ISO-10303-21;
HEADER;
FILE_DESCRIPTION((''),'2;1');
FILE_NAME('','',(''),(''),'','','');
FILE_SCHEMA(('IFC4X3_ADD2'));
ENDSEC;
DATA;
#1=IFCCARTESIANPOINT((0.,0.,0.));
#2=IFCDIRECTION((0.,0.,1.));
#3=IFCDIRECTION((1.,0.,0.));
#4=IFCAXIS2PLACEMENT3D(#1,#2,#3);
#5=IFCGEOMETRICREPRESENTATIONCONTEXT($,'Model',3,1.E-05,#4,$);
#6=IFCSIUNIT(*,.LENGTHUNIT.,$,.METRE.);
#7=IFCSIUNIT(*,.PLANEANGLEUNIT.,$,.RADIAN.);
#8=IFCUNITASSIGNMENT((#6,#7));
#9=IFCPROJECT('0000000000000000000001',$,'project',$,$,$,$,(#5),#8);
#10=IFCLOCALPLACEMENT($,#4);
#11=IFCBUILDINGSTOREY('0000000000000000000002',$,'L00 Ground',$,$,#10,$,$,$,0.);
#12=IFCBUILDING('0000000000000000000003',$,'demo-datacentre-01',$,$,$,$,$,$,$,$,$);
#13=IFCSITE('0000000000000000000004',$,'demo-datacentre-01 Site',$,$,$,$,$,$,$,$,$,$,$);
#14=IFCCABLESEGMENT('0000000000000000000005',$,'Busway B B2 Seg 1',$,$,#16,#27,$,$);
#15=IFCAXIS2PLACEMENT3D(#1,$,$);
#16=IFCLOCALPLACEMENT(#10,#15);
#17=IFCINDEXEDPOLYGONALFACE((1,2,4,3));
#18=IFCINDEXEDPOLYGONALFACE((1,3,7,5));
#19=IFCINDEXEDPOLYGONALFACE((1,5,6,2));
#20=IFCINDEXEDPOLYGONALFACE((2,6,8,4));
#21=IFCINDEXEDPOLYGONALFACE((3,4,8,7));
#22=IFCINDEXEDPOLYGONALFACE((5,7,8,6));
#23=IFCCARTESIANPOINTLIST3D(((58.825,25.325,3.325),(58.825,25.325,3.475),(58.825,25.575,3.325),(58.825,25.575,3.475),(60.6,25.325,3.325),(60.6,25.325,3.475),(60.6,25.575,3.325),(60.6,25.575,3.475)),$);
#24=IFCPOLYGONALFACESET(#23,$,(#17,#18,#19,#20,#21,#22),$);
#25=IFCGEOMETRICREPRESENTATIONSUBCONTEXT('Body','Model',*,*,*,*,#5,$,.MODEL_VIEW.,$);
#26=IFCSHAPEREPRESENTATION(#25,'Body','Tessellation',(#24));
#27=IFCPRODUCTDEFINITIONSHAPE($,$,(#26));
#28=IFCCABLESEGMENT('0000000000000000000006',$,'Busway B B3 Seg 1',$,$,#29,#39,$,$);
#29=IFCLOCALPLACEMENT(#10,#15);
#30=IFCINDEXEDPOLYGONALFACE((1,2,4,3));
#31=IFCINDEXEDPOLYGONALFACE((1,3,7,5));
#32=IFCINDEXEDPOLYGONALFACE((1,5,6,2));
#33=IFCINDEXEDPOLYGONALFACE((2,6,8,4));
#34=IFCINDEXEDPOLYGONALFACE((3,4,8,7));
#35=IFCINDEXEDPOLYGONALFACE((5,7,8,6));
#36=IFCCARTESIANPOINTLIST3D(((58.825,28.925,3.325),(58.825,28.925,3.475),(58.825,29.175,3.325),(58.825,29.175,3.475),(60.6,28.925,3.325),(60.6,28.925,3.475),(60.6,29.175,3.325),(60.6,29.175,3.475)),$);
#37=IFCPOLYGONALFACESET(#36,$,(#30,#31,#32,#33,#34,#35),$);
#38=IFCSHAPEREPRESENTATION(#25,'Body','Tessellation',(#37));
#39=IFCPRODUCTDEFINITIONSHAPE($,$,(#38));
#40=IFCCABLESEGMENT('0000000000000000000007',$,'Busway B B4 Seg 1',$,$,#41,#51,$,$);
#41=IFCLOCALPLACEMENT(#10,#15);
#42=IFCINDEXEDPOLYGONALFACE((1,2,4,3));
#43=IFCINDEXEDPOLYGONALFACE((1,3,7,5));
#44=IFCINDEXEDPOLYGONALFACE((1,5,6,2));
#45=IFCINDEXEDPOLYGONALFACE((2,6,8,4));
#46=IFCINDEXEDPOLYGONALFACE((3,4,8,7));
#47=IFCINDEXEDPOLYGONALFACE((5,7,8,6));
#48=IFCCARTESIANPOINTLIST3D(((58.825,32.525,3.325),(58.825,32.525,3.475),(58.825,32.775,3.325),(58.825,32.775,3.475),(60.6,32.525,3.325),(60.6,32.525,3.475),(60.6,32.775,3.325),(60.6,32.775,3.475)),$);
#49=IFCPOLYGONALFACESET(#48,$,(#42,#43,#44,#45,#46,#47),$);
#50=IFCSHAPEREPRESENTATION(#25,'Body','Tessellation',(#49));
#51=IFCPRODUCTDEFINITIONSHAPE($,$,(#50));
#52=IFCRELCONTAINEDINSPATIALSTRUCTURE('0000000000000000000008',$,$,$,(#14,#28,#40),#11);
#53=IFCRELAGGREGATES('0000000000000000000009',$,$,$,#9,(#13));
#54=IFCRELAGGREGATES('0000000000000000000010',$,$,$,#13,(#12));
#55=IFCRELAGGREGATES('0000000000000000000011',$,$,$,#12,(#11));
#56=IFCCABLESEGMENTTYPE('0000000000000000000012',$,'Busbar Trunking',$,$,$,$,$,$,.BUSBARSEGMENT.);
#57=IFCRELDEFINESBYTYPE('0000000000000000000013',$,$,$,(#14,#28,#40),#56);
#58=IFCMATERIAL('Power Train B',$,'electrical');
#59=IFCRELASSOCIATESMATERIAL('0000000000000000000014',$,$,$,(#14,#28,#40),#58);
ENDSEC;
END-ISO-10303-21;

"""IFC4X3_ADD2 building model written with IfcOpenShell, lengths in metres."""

from ifc_helpers import new_model, si_unit, frame, origin_with_axes, place, context, subcontext, project, spatial, rectangle, extrude, material, type_object, element, save


model = new_model("IFC4X3_ADD2")

# Units and contexts
model_context = context("Model", 3, precision=1e-05, world=origin_with_axes())
body_context = subcontext(model_context, "Body", "Model", "MODEL_VIEW")
ifc_project = project(units=[si_unit("LENGTHUNIT", "METRE"), si_unit("PLANEANGLEUNIT", "RADIAN")], contexts=[model_context])

# Site, building, storey
site = spatial("IfcSite", under=ifc_project, Name="demo-datacentre-01 Site")
building = spatial("IfcBuilding", under=site, Name="demo-datacentre-01")
storey_placement = place(None, origin_with_axes())
storey = spatial("IfcBuildingStorey", under=building, at=storey_placement, Name="L00 Ground", Elevation=0.0)

# Shared definitions
ifc_material = material(Name="Power Train B", Category="electrical")

# Cable segments
cable_segment_type_1 = type_object("IfcCableSegmentType", Name="Busbar Trunking", PredefinedType="BUSBARSEGMENT")
for number, where, z_axis, x_axis, name in (
    (1, (60.6, 25.45, 3.4), (-1.0, 0.0, 0.0), (0.0, -1.0, 0.0), "Busway B B2 Seg 1"),
    (2, (60.6, 29.05, 3.4), (-1.0, 0.0, 0.0), (0.0, -1.0, 0.0), "Busway B B3 Seg 1"),
    (3, (60.6, 32.65, 3.4), (-1.0, 0.0, 0.0), (0.0, -1.0, 0.0), "Busway B B4 Seg 1"),
):
    element("IfcCableSegment", number, at=place(storey_placement, frame(where, z_axis=z_axis, x_axis=x_axis)), inside=storey, type_object=cable_segment_type_1, material=ifc_material, Name=name, context=body_context, shape_type="SweptSolid", body=[
        extrude(rectangle(XDim=0.25, YDim=0.15), origin_with_axes(), (0.0, 0.0, 1.0), 1.775),
    ])

save(model, "model.ifc")
